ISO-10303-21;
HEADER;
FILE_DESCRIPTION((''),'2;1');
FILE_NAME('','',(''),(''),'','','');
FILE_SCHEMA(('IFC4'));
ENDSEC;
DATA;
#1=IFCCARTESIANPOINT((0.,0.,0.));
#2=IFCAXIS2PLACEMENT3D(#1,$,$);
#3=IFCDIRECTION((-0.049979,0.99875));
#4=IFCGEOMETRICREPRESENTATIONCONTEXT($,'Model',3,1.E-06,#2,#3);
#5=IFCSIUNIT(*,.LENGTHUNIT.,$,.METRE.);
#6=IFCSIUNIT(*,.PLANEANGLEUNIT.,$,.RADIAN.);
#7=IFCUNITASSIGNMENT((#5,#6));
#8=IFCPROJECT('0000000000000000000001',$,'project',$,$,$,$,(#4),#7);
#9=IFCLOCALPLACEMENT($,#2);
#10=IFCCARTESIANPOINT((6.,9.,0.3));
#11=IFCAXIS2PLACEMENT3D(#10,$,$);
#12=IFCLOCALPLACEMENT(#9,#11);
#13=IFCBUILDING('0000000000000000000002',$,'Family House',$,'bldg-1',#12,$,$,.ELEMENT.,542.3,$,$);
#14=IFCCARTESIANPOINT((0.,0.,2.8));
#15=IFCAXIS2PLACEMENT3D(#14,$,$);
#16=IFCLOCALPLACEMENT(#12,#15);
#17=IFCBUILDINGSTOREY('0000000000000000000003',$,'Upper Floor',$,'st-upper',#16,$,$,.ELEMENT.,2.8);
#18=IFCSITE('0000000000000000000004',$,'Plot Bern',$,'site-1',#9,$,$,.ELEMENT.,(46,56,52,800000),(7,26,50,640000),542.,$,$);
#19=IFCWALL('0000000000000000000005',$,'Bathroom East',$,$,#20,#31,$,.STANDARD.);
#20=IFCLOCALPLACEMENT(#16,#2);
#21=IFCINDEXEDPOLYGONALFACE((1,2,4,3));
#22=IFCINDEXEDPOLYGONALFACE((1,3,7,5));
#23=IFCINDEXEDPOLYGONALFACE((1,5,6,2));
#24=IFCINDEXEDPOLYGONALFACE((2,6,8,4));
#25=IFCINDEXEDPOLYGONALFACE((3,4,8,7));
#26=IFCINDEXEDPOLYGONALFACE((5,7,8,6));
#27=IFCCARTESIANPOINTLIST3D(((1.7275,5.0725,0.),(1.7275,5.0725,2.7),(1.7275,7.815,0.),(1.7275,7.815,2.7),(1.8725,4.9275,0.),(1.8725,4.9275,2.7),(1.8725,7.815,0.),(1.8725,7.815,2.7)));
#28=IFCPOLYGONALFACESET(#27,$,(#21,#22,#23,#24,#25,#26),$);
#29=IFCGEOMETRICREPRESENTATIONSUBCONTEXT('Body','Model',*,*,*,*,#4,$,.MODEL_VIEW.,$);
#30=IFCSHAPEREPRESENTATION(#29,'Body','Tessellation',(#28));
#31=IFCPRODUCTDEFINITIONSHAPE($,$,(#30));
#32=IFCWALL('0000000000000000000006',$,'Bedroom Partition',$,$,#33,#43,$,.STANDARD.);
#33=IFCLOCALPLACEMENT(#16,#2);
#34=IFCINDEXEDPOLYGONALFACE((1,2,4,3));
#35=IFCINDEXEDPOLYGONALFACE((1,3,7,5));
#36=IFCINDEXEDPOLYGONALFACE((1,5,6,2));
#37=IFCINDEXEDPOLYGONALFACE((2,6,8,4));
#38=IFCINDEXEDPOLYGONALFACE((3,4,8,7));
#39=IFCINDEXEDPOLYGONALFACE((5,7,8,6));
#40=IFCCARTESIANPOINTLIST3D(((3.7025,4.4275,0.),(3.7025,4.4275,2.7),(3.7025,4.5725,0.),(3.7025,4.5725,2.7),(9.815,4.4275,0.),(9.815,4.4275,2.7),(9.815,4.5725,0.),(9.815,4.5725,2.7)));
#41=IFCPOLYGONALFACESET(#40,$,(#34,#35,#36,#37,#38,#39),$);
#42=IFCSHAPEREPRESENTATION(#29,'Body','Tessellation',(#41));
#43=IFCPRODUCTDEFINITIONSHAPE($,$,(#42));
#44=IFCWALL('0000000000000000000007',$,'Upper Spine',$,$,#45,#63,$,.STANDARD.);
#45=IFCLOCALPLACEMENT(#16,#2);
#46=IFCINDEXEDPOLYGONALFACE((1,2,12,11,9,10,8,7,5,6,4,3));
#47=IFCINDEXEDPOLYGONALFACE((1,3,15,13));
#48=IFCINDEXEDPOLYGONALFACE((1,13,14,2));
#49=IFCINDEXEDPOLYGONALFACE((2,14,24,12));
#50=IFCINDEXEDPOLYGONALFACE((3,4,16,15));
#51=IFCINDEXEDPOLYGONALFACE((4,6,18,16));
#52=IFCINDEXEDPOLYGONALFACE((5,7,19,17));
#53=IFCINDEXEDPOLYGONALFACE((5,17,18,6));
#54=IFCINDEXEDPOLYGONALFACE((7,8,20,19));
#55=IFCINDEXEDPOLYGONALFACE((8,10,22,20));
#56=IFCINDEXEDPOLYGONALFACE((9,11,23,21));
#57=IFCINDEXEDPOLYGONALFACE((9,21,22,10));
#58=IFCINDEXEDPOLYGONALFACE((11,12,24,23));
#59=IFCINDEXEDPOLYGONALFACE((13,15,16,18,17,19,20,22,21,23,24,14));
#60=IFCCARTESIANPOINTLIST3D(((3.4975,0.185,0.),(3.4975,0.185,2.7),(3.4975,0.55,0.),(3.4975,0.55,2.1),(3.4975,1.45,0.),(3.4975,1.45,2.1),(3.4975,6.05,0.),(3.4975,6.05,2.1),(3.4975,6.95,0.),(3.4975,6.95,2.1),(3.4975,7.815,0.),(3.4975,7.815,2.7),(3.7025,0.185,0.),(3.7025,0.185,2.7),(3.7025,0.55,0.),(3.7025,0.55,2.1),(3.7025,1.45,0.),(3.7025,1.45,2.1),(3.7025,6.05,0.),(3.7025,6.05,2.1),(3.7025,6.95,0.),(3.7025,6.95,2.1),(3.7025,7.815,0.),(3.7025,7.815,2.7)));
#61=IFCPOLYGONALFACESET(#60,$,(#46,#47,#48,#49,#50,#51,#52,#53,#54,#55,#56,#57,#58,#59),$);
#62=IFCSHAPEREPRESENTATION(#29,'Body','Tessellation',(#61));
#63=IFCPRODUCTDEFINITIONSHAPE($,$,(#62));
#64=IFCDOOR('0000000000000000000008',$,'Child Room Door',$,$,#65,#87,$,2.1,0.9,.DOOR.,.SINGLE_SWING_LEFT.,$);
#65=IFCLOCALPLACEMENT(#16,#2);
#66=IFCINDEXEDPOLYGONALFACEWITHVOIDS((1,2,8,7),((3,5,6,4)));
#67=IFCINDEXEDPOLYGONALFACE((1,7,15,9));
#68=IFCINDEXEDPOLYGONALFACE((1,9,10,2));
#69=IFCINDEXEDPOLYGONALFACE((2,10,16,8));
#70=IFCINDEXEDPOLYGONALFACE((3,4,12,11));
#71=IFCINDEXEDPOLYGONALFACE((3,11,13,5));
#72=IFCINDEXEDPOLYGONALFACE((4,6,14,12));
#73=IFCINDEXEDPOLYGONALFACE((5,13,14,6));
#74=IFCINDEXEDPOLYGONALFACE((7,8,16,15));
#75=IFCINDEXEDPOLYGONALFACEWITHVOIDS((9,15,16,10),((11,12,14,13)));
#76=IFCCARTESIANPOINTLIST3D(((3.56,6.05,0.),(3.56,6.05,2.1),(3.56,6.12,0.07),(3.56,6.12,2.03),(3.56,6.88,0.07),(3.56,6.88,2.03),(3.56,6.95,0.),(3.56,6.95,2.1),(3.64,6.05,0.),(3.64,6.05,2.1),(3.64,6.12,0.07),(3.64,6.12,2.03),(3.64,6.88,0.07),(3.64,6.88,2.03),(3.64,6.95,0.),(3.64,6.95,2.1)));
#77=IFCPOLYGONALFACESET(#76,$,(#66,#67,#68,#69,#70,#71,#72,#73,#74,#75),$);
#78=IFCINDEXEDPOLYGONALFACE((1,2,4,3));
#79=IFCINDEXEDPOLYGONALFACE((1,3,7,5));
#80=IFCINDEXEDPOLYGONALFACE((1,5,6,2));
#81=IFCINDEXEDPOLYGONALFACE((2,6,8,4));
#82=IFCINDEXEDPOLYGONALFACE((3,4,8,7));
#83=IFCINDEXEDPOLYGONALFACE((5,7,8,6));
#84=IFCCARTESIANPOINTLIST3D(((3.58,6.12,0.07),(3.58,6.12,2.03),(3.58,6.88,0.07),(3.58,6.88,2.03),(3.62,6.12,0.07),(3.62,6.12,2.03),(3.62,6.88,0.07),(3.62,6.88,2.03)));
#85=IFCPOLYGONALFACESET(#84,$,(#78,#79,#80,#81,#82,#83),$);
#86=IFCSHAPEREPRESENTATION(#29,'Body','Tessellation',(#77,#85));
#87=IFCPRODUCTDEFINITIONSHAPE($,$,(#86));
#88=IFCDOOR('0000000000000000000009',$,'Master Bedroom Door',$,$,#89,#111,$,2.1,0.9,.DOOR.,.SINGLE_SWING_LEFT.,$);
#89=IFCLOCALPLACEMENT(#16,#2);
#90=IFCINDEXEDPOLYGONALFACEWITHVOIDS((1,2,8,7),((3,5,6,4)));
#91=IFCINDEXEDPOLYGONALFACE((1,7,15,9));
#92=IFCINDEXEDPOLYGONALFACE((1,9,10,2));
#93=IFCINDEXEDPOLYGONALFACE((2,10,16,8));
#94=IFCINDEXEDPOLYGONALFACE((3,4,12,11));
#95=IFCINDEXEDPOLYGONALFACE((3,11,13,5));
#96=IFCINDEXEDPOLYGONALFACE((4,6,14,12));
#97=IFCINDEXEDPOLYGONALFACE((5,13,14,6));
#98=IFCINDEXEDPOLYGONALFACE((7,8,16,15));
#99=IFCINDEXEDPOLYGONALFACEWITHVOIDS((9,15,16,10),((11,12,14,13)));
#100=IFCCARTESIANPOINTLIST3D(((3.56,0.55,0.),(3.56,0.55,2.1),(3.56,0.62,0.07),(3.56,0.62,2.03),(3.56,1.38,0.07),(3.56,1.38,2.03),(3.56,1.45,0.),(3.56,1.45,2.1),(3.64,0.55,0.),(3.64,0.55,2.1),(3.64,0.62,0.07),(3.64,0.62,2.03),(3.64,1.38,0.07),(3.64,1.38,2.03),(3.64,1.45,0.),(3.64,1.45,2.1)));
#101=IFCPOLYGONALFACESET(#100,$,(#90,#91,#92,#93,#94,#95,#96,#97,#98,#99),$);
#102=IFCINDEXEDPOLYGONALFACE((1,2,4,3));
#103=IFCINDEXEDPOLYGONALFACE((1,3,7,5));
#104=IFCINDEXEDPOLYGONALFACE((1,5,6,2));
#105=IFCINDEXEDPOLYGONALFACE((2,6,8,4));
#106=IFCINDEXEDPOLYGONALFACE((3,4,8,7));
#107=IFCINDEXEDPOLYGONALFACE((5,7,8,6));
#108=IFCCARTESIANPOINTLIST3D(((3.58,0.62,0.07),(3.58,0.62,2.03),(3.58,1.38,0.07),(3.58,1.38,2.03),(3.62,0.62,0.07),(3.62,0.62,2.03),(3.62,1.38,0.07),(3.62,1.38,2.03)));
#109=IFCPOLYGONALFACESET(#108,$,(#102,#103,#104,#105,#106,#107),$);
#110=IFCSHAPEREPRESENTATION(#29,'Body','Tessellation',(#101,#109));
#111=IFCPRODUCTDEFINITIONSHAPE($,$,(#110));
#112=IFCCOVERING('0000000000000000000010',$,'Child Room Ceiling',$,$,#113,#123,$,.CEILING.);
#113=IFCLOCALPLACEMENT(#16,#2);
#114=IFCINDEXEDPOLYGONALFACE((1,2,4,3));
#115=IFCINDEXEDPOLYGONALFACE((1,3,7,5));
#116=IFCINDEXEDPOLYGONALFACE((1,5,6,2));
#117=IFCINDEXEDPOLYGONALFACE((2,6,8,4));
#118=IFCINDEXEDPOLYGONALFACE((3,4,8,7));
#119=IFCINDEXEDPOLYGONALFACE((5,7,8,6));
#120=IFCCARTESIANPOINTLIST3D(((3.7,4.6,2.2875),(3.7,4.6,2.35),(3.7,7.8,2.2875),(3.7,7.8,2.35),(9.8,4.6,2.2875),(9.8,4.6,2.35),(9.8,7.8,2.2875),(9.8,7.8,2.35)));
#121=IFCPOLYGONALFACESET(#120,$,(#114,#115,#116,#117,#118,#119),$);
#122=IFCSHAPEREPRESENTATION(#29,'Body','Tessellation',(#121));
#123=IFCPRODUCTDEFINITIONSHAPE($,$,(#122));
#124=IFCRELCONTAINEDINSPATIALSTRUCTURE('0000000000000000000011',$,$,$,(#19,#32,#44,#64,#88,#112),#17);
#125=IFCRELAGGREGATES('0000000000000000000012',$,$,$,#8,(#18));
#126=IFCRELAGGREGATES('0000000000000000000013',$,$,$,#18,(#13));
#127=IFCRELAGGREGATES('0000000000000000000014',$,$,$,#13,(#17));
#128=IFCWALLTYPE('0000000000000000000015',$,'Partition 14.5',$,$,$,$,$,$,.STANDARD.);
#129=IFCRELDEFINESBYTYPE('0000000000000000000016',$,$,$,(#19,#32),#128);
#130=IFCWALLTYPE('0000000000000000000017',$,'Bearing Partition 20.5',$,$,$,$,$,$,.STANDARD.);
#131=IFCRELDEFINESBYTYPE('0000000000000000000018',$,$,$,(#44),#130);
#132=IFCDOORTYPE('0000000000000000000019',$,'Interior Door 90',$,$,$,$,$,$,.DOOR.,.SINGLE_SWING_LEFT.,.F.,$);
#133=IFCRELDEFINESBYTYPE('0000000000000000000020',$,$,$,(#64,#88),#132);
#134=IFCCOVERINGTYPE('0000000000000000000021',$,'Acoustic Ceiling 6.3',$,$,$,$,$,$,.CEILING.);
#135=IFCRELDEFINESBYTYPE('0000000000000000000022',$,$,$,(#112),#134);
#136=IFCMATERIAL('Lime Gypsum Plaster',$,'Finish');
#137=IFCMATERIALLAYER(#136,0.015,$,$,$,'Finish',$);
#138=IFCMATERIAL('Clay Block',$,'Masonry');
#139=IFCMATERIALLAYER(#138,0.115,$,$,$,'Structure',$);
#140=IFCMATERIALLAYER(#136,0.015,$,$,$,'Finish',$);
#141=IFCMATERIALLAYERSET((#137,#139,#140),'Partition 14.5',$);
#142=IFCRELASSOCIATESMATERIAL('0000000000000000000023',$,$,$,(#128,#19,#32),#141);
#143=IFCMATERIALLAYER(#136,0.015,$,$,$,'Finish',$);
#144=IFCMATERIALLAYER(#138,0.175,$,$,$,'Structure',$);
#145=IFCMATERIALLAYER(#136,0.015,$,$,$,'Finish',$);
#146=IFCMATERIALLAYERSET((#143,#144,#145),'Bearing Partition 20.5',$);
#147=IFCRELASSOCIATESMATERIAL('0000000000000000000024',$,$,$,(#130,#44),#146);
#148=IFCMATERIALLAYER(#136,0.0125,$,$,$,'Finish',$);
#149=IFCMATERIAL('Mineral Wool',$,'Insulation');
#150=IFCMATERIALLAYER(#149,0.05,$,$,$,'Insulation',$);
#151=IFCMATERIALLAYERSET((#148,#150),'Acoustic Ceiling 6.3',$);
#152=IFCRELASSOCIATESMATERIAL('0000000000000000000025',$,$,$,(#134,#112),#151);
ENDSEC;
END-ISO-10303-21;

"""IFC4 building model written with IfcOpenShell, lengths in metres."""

from ifc_helpers import new_model, si_unit, direction, frame, frame_2d, origin, origin_2d, place, context, subcontext, project, spatial, polyline, rectangle, outline, extrude, material, layer, layer_set, layer_usage, type_object, element, fill, save


model = new_model("IFC4")

# Units and contexts
model_context = context("Model", 3, precision=1e-06, world=origin(), true_north=direction((-0.049979, 0.99875)))
body_context = subcontext(model_context, "Body", "Model", "MODEL_VIEW")
ifc_project = project(units=[si_unit("LENGTHUNIT", "METRE"), si_unit("PLANEANGLEUNIT", "RADIAN")], contexts=[model_context])

# Site, building, storey
site_placement = place(None, origin())
site = spatial("IfcSite", under=ifc_project, at=site_placement, Name="Plot Bern", ObjectType="site-1", CompositionType="ELEMENT", RefLatitude=(46, 56, 52, 800000), RefLongitude=(7, 26, 50, 640000), RefElevation=542.0)
building_placement = place(site_placement, frame((6.0, 9.0, 0.3)))
building = spatial("IfcBuilding", under=site, at=building_placement, Name="Family House", ObjectType="bldg-1", CompositionType="ELEMENT", ElevationOfRefHeight=542.3)
storey_placement = place(building_placement, frame((0.0, 0.0, 2.8)))
storey = spatial("IfcBuildingStorey", under=building, at=storey_placement, Name="Upper Floor", ObjectType="st-upper", CompositionType="ELEMENT", Elevation=2.8)

# Shared definitions
ifc_material_1 = material(Name="Mineral Wool", Category="Insulation")

# Shared definitions
ifc_material_2 = material(Name="Lime Gypsum Plaster", Category="Finish")
ifc_material_3 = material(Name="Clay Block", Category="Masonry")

# Shared definitions
ifc_layer_1 = layer(ifc_material_2, 0.015, Category="Finish")
ifc_layer_2 = layer(ifc_material_3, 0.115, Category="Structure")
ifc_layer_3 = layer(ifc_material_2, 0.015, Category="Finish")
ifc_layer_set_1 = layer_set([ifc_layer_1, ifc_layer_2, ifc_layer_3], Name="Partition 14.5")
wall_type_1 = type_object("IfcWallType", Name="Partition 14.5", PredefinedType="STANDARD", material=ifc_layer_set_1)

# Walls
ifc_layer_usage_1 = layer_usage(ifc_layer_set_1, "AXIS2", "NEGATIVE", 0.0725)
wall_1_placement = place(storey_placement, origin())
element("IfcWall", 1, at=wall_1_placement, inside=storey, type_object=wall_type_1, material=ifc_layer_usage_1, Name="Bathroom East", PredefinedType="STANDARD", context=body_context, shape_type="SweptSolid", body=[
    extrude(outline(polyline([(1.8725, 4.9275), (1.8725, 7.815), (1.7275, 7.815), (1.7275, 5.0725), (1.8725, 4.9275)])), origin(), (0.0, 0.0, 1.0), 2.7),
])
ifc_layer_usage_2 = layer_usage(ifc_layer_set_1, "AXIS2", "NEGATIVE", 0.0725)
wall_2_placement = place(storey_placement, origin())
element("IfcWall", 2, at=wall_2_placement, inside=storey, type_object=wall_type_1, material=ifc_layer_usage_2, Name="Bedroom Partition", PredefinedType="STANDARD", context=body_context, shape_type="SweptSolid", body=[
    extrude(outline(polyline([(3.7025, 4.4275), (9.815, 4.4275), (9.815, 4.5725), (3.7025, 4.5725), (3.7025, 4.4275)])), origin(), (0.0, 0.0, 1.0), 2.7),
])

# Wall, openings, doors
ifc_layer_4 = layer(ifc_material_2, 0.015, Category="Finish")
ifc_layer_5 = layer(ifc_material_3, 0.175, Category="Structure")
ifc_layer_6 = layer(ifc_material_2, 0.015, Category="Finish")
ifc_layer_set_2 = layer_set([ifc_layer_4, ifc_layer_5, ifc_layer_6], Name="Bearing Partition 20.5")
ifc_layer_usage_3 = layer_usage(ifc_layer_set_2, "AXIS2", "NEGATIVE", 0.1025)
wall_type_2 = type_object("IfcWallType", Name="Bearing Partition 20.5", PredefinedType="STANDARD", material=ifc_layer_set_2)
wall_3_placement = place(storey_placement, origin())
wall_3 = element("IfcWall", 3, at=wall_3_placement, inside=storey, type_object=wall_type_2, material=ifc_layer_usage_3, Name="Upper Spine", PredefinedType="STANDARD", context=body_context, shape_type="SweptSolid", body=[
    extrude(outline(polyline([(3.7025, 0.185), (3.7025, 7.815), (3.4975, 7.815), (3.4975, 0.185), (3.7025, 0.185)])), origin(), (0.0, 0.0, 1.0), 2.7),
])
opening_1_placement = place(wall_3_placement, frame((3.6, 6.5, 0.0), z_axis=(0.0, 0.0, 1.0), x_axis=(0.0, 1.0, 0.0)))
opening_1 = element("IfcOpeningElement", 4, at=opening_1_placement, cuts=wall_3, PredefinedType="OPENING", context=body_context, shape_type="SweptSolid", body=[
    extrude(rectangle(XDim=0.9, YDim=0.205, at=origin_2d()), origin(), (0.0, 0.0, 1.0), 2.1),
])
opening_2_placement = place(wall_3_placement, frame((3.6, 1.0, 0.0), z_axis=(0.0, 0.0, 1.0), x_axis=(0.0, 1.0, 0.0)))
opening_2 = element("IfcOpeningElement", 5, at=opening_2_placement, cuts=wall_3, PredefinedType="OPENING", context=body_context, shape_type="SweptSolid", body=[
    extrude(rectangle(XDim=0.9, YDim=0.205, at=origin_2d()), origin(), (0.0, 0.0, 1.0), 2.1),
])
door_type_1 = type_object("IfcDoorType", Name="Interior Door 90", OperationType="SINGLE_SWING_LEFT", ParameterTakesPrecedence=False, PredefinedType="DOOR")
door_1_placement = place(opening_1_placement, frame((0.0, 0.0, 0.0), z_axis=(0.0, -1.0, 0.0), x_axis=(1.0, 0.0, 0.0)))
door_1 = element("IfcDoor", 6, at=door_1_placement, inside=storey, type_object=door_type_1, Name="Child Room Door", OperationType="SINGLE_SWING_LEFT", OverallHeight=2.1, OverallWidth=0.9, PredefinedType="DOOR", context=body_context, shape_type="SweptSolid", body=[
    extrude(outline(polyline([(-0.45, 0.0), (0.45, 0.0), (0.45, 2.1), (-0.45, 2.1), (-0.45, 0.0)]), holes=[polyline([(-0.38, 0.07), (0.38, 0.07), (0.38, 2.03), (-0.38, 2.03), (-0.38, 0.07)])]), frame((0.0, 0.0, -0.04)), (0.0, 0.0, 1.0), 0.08),
    extrude(rectangle(XDim=0.76, YDim=1.96, at=frame_2d((0.0, 1.05))), frame((0.0, 0.0, -0.02)), (0.0, 0.0, 1.0), 0.04),
])
fill(opening_1, door_1)
door_2_placement = place(opening_2_placement, frame((0.0, 0.0, 0.0), z_axis=(0.0, -1.0, 0.0), x_axis=(1.0, 0.0, 0.0)))
door_2 = element("IfcDoor", 7, at=door_2_placement, inside=storey, type_object=door_type_1, Name="Master Bedroom Door", OperationType="SINGLE_SWING_LEFT", OverallHeight=2.1, OverallWidth=0.9, PredefinedType="DOOR", context=body_context, shape_type="SweptSolid", body=[
    extrude(outline(polyline([(-0.45, 0.0), (0.45, 0.0), (0.45, 2.1), (-0.45, 2.1), (-0.45, 0.0)]), holes=[polyline([(-0.38, 0.07), (0.38, 0.07), (0.38, 2.03), (-0.38, 2.03), (-0.38, 0.07)])]), frame((0.0, 0.0, -0.04)), (0.0, 0.0, 1.0), 0.08),
    extrude(rectangle(XDim=0.76, YDim=1.96, at=frame_2d((0.0, 1.05))), frame((0.0, 0.0, -0.02)), (0.0, 0.0, 1.0), 0.04),
])
fill(opening_2, door_2)

# Covering
ifc_layer_7 = layer(ifc_material_2, 0.0125, Category="Finish")
ifc_layer_8 = layer(ifc_material_1, 0.05, Category="Insulation")
ifc_layer_set_3 = layer_set([ifc_layer_7, ifc_layer_8], Name="Acoustic Ceiling 6.3")
ifc_layer_usage_4 = layer_usage(ifc_layer_set_3, "AXIS3", "NEGATIVE", 0.0625)
covering_type = type_object("IfcCoveringType", Name="Acoustic Ceiling 6.3", PredefinedType="CEILING", material=ifc_layer_set_3)
covering_placement = place(storey_placement, frame((0.0, 0.0, 2.2875)))
element("IfcCovering", 8, at=covering_placement, inside=storey, type_object=covering_type, material=ifc_layer_usage_4, Name="Child Room Ceiling", PredefinedType="CEILING", context=body_context, shape_type="SweptSolid", body=[
    extrude(outline(polyline([(3.7, 4.6), (9.8, 4.6), (9.8, 7.8), (3.7, 7.8), (3.7, 4.6)])), origin(), (0.0, 0.0, 1.0), 0.0625),
])

save(model, "model.ifc")
